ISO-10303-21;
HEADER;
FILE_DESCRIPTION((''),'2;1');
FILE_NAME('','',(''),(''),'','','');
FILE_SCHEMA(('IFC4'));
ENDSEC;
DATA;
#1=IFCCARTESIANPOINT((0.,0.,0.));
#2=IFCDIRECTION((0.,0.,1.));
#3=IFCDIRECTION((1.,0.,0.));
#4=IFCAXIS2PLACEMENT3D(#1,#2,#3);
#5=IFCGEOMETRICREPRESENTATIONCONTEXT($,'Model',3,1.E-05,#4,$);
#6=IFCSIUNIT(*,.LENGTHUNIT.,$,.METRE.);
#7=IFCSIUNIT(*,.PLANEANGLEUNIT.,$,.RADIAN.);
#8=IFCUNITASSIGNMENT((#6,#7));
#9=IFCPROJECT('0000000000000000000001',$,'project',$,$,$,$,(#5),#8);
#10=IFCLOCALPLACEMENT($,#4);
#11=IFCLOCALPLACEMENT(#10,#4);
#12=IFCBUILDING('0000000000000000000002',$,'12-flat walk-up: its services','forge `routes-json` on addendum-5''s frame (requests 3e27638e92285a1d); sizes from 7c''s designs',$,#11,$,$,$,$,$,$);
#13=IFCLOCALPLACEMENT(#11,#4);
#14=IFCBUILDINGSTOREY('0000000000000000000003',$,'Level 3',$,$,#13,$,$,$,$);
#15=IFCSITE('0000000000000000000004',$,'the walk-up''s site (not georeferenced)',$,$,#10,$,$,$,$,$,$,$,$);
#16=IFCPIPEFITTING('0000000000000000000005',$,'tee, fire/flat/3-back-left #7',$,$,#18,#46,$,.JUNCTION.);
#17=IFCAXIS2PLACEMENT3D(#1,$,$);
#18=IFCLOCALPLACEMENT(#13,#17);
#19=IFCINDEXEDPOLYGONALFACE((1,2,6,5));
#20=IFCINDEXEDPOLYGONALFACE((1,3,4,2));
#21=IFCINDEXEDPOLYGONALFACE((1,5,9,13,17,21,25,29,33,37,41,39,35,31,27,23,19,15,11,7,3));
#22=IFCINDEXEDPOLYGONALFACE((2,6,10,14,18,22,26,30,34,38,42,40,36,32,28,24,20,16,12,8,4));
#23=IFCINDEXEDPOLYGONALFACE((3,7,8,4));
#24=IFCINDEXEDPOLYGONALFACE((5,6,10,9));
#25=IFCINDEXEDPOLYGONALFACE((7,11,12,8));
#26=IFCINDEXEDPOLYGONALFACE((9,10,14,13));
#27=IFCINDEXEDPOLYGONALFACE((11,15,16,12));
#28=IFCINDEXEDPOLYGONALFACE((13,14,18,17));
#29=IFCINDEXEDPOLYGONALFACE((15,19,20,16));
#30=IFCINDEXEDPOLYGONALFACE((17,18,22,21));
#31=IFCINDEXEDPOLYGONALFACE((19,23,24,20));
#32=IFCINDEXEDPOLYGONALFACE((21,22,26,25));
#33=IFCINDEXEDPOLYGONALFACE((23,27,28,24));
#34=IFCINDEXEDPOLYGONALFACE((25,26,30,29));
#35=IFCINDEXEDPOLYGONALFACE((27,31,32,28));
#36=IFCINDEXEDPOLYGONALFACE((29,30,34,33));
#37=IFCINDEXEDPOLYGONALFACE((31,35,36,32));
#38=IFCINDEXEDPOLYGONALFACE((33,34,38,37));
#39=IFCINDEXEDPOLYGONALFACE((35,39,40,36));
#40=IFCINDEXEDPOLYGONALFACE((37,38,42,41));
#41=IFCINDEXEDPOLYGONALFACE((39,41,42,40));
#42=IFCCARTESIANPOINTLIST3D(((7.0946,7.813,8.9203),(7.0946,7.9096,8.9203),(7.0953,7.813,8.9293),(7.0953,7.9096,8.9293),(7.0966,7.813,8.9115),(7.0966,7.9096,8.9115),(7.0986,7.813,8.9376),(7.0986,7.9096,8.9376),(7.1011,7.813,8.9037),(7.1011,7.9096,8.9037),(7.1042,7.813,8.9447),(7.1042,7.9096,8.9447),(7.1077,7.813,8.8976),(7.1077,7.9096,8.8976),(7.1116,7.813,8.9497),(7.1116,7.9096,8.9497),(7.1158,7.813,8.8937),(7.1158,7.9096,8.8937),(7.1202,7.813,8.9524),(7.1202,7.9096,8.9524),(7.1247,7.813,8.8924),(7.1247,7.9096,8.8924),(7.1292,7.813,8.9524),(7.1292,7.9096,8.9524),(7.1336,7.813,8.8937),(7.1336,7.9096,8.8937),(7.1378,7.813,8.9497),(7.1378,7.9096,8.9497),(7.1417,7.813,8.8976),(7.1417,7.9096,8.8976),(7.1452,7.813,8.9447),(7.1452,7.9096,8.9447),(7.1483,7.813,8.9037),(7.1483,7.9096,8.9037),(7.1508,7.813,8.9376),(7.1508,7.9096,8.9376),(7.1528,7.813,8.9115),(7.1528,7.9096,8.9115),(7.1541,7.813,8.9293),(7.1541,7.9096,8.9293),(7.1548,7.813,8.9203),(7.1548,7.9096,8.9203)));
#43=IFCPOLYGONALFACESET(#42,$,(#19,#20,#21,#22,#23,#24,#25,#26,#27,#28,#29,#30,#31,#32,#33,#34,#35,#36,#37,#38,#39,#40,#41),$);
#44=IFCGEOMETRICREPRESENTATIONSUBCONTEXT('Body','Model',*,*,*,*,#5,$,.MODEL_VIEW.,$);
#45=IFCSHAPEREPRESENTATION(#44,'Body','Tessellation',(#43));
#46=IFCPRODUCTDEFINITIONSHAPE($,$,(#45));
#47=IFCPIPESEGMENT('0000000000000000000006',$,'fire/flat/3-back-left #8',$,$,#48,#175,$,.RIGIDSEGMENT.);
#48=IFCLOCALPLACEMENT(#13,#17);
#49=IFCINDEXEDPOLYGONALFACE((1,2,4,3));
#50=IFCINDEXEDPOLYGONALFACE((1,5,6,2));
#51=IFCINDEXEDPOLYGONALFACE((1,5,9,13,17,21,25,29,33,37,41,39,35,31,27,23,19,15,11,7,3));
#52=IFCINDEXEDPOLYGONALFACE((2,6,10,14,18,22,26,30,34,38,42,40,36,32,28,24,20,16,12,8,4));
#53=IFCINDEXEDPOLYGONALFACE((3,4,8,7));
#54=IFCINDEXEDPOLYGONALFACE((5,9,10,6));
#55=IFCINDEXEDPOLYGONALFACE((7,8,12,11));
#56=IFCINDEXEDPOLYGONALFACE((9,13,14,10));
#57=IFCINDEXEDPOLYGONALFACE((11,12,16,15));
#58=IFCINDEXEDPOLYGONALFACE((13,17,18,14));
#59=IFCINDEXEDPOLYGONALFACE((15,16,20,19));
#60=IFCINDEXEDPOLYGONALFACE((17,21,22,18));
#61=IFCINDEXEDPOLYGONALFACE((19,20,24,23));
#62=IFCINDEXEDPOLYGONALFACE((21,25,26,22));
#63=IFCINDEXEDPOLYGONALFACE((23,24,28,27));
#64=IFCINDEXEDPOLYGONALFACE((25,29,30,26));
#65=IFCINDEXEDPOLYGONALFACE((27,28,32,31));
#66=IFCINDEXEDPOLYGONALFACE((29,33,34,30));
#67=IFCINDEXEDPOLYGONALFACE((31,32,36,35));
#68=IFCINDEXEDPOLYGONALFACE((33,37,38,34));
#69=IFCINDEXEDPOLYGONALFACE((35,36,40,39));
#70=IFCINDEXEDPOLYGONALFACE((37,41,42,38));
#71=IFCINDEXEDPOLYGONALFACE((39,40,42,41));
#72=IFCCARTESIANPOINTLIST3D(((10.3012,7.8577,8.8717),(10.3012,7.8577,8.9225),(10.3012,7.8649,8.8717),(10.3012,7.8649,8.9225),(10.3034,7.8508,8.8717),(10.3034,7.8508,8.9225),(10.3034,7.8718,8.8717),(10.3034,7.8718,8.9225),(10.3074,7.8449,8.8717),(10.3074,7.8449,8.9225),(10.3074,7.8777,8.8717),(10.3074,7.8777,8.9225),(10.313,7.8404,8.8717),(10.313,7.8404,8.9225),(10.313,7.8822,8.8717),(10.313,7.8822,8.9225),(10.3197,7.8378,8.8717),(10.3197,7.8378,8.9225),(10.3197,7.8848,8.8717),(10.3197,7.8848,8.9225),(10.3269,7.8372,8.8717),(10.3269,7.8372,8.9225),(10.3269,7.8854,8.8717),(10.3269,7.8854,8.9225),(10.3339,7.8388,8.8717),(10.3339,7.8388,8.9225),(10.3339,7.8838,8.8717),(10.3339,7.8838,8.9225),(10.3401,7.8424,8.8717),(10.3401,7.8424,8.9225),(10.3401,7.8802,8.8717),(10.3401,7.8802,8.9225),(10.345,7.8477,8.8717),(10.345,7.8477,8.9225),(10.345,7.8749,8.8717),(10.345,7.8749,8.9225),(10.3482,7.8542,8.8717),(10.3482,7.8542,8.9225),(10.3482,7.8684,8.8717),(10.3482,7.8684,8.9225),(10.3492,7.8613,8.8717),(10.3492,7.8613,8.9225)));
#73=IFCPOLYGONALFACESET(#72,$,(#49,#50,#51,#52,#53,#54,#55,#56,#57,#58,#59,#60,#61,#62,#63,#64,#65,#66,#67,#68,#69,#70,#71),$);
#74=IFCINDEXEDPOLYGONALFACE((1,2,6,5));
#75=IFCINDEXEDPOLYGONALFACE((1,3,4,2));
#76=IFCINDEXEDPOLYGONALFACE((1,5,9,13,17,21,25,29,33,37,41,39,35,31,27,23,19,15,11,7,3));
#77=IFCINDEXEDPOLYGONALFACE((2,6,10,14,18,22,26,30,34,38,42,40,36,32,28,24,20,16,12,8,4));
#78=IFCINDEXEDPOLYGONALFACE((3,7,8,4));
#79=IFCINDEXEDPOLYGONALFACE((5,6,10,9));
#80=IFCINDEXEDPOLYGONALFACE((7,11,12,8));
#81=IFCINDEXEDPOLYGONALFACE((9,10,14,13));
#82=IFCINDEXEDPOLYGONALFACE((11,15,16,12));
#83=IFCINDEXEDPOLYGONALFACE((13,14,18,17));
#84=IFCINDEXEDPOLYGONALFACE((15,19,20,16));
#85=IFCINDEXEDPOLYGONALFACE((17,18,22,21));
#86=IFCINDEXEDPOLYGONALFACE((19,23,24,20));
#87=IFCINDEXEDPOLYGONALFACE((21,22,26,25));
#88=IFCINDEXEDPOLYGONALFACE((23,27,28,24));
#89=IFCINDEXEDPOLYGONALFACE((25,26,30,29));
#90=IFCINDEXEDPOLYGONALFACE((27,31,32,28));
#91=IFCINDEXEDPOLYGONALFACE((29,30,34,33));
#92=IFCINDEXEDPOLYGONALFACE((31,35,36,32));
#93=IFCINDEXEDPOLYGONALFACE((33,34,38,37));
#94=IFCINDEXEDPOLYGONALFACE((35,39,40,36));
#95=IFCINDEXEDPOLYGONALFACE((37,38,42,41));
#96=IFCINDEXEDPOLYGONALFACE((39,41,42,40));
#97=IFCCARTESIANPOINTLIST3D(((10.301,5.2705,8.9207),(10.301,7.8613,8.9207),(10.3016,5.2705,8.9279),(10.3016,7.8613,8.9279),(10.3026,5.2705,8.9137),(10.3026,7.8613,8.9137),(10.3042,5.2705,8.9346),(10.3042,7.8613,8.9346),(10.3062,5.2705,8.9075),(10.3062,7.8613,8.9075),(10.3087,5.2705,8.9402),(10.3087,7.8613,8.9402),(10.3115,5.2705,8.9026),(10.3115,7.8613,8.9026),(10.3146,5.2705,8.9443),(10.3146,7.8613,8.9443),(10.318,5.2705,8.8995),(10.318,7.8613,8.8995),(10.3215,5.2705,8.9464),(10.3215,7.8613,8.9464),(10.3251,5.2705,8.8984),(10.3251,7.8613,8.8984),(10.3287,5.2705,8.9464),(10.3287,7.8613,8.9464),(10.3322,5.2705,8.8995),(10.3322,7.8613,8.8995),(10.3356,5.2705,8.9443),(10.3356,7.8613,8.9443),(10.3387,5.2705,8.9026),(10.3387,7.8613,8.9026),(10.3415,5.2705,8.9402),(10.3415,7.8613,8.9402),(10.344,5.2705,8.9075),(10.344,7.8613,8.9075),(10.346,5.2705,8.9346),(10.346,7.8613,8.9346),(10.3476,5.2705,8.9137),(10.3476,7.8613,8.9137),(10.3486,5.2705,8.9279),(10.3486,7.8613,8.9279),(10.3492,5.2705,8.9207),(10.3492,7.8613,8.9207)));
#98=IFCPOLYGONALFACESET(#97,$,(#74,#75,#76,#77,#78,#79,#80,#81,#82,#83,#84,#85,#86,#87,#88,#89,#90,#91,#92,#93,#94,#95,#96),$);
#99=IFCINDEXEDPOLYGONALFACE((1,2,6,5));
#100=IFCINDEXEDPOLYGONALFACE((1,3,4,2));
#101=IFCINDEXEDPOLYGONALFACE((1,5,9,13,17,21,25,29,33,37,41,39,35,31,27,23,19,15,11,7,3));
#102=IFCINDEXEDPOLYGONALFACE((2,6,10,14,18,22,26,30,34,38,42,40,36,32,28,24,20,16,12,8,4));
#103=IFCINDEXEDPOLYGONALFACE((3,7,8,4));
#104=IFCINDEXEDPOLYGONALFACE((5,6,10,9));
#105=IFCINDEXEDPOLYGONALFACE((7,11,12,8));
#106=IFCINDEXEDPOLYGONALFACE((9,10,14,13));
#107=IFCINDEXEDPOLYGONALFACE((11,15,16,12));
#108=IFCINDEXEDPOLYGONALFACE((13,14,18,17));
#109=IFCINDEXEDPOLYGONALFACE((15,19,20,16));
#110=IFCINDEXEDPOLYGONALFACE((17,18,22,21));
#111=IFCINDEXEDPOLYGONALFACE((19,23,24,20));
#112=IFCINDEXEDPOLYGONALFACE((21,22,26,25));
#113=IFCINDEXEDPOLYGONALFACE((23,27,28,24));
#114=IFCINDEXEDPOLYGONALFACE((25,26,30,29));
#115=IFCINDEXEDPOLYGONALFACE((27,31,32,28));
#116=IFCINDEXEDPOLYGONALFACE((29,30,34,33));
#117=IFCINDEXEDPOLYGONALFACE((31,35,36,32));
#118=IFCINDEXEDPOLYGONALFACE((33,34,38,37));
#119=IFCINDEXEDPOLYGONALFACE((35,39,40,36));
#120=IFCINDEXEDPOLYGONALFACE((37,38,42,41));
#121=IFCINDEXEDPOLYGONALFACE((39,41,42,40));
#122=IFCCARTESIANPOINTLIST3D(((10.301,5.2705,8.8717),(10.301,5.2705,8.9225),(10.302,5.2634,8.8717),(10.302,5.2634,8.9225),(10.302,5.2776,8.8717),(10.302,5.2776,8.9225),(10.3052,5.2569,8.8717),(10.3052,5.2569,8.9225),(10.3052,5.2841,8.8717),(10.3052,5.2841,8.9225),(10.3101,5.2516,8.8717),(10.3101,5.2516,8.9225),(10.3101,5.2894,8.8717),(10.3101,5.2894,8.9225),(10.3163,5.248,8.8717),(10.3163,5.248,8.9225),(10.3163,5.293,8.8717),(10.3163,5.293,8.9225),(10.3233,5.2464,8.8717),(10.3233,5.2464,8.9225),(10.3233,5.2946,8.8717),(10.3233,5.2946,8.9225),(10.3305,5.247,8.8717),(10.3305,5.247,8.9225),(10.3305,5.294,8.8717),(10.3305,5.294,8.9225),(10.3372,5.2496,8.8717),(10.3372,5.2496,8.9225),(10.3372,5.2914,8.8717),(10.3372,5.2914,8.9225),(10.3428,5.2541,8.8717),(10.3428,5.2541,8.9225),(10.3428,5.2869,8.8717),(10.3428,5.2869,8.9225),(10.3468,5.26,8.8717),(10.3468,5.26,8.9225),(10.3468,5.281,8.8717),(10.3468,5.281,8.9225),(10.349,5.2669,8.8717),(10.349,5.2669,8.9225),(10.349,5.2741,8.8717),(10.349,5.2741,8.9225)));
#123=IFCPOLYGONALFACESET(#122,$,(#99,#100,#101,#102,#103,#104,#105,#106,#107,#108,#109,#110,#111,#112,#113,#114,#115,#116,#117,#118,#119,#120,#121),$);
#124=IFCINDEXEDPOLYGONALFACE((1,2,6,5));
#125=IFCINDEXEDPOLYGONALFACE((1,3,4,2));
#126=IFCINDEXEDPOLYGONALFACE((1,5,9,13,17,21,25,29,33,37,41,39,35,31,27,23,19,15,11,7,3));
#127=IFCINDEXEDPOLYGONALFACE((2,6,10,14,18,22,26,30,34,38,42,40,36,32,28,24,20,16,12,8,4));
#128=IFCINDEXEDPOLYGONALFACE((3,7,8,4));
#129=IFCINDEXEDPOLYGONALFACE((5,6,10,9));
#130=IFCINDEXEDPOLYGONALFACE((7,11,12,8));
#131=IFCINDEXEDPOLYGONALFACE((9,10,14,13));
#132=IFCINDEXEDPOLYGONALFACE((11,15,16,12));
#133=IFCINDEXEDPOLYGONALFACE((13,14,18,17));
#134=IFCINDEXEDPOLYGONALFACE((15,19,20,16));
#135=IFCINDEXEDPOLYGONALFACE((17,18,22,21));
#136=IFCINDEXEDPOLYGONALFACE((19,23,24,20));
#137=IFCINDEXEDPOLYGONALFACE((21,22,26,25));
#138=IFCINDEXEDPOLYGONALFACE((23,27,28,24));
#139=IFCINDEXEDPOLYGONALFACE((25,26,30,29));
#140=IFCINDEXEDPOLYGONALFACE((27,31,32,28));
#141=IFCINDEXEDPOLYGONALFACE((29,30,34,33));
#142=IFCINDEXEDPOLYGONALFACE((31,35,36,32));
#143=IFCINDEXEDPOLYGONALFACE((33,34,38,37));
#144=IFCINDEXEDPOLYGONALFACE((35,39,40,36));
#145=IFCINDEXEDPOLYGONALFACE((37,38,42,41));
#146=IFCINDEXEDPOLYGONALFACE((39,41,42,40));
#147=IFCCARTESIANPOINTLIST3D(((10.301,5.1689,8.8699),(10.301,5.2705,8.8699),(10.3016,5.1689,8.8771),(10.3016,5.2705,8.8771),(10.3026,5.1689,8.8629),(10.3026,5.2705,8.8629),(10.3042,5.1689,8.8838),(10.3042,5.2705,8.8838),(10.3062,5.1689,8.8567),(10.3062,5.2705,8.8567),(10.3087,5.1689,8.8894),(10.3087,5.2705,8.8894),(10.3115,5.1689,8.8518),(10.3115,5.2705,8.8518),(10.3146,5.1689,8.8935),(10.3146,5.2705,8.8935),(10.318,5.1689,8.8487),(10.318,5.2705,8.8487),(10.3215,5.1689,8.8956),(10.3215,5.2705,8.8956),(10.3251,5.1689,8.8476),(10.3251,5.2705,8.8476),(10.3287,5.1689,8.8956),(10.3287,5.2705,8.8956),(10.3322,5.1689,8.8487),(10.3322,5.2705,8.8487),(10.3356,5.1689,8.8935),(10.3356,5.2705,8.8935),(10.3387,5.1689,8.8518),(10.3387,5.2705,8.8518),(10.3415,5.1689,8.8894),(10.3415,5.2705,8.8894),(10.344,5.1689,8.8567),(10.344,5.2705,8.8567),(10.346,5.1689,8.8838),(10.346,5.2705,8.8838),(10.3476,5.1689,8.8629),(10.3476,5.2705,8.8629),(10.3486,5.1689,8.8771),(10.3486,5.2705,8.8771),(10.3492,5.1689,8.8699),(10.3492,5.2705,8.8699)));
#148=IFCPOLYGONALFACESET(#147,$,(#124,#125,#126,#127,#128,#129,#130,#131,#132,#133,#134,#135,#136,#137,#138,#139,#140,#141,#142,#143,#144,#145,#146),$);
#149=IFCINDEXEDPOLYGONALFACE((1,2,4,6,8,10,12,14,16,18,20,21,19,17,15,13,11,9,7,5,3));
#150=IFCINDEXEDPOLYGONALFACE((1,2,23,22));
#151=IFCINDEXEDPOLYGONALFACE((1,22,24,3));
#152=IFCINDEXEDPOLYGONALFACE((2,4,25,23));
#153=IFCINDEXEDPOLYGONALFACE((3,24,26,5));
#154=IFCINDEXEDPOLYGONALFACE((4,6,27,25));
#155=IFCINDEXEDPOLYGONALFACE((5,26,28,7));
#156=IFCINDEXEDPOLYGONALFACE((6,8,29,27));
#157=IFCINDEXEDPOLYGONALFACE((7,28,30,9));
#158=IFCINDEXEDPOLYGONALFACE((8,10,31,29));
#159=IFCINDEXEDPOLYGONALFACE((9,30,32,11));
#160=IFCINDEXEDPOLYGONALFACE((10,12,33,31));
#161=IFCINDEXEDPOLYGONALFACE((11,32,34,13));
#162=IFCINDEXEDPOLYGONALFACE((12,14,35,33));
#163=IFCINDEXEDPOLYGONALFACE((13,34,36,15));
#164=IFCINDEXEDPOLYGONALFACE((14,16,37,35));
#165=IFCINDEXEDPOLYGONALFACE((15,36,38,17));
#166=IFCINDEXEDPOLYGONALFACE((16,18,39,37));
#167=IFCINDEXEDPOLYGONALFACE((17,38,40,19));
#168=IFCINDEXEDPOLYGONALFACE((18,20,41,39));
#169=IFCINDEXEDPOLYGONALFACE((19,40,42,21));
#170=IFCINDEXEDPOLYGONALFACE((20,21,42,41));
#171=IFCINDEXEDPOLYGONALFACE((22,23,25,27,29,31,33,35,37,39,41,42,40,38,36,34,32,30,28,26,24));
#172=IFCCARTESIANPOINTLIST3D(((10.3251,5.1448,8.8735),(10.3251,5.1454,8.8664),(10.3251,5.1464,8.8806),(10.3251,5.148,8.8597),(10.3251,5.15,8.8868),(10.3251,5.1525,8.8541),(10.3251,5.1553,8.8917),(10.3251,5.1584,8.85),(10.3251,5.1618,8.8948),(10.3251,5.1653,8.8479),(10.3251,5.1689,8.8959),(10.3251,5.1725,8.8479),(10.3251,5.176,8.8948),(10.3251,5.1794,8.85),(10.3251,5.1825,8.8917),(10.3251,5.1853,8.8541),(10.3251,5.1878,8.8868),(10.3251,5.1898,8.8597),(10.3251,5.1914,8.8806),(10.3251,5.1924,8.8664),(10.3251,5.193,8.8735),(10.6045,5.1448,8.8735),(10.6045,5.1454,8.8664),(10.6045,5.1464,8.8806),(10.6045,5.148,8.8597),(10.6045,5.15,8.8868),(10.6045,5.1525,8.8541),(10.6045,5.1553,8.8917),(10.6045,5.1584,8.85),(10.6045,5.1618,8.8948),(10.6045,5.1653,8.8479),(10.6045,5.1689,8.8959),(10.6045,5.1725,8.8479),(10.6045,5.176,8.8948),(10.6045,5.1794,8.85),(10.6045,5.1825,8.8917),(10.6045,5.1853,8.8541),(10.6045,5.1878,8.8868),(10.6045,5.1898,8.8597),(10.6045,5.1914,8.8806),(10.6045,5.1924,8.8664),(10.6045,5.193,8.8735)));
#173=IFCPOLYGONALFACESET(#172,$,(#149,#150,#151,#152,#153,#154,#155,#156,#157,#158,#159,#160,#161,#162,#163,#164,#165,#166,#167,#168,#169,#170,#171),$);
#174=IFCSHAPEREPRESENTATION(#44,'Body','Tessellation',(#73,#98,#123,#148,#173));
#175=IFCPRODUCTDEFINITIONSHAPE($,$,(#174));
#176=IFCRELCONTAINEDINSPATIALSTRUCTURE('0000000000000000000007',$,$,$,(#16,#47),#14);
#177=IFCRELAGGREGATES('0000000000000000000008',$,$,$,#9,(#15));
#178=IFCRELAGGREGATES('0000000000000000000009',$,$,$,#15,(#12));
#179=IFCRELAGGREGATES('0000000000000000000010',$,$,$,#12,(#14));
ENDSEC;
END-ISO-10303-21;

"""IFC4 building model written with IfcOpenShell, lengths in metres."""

from ifc_helpers import new_model, entity, si_unit, frame, origin_with_axes, place, context, subcontext, project, spatial, element, save


model = new_model("IFC4")

# Units and contexts
model_context = context("Model", 3, precision=1e-05, world=origin_with_axes())
body_context = subcontext(model_context, "Body", "Model", "MODEL_VIEW")
ifc_project = project(units=[si_unit("LENGTHUNIT", "METRE"), si_unit("PLANEANGLEUNIT", "RADIAN")], contexts=[model_context])

# Site, building, storey
site_placement = place(None, origin_with_axes())
site = spatial("IfcSite", under=ifc_project, at=site_placement, Name="the walk-up's site (not georeferenced)")
building_placement = place(site_placement, origin_with_axes())
building = spatial("IfcBuilding", under=site, at=building_placement, Name="12-flat walk-up: its services", Description="forge `routes-json` on addendum-5's frame (requests 3e27638e92285a1d); sizes from 7c's designs")
storey_placement = place(building_placement, origin_with_axes())
storey = spatial("IfcBuildingStorey", under=building, at=storey_placement, Name="Level 3")

# Pipe fitting
pipe_fitting_1_placement = place(storey_placement, frame((7.1247, 7.9096, 8.9225), z_axis=(0.0, 0.0, 1.0), x_axis=(1.0, 0.0, 0.0)))
element("IfcPipeFitting", 1, at=pipe_fitting_1_placement, inside=storey, Name="tee, fire/flat/3-back-left #7", PredefinedType="JUNCTION", context=body_context, shape_type="AdvancedSweptSolid", body=[
    entity("IfcSweptDiskSolid", entity("IfcPolyline", [entity("IfcCartesianPoint", [0.0, 0.0, 0.0]), entity("IfcCartesianPoint", [0.0, -0.0965, 0.0])]), 0.0302),
])

# Pipe segment
pipe_segment_1_placement = place(storey_placement, frame((10.3251, 7.8613, 8.8717), z_axis=(0.0, 0.0, 1.0), x_axis=(1.0, 0.0, 0.0)))
element("IfcPipeSegment", 2, at=pipe_segment_1_placement, inside=storey, Name="fire/flat/3-back-left #8", PredefinedType="RIGIDSEGMENT", context=body_context, shape_type="AdvancedSweptSolid", body=[
    entity("IfcSweptDiskSolid", entity("IfcPolyline", [entity("IfcCartesianPoint", [0.0, 0.0, 0.0]), entity("IfcCartesianPoint", [0.0, 0.0, 0.0508])]), 0.0241),
    entity("IfcSweptDiskSolid", entity("IfcPolyline", [entity("IfcCartesianPoint", [0.0, 0.0, 0.0508]), entity("IfcCartesianPoint", [0.0, -2.5908, 0.0508])]), 0.0241),
    entity("IfcSweptDiskSolid", entity("IfcPolyline", [entity("IfcCartesianPoint", [0.0, -2.5908, 0.0508]), entity("IfcCartesianPoint", [0.0, -2.5908, 0.0])]), 0.0241),
    entity("IfcSweptDiskSolid", entity("IfcPolyline", [entity("IfcCartesianPoint", [0.0, -2.5908, 0.0]), entity("IfcCartesianPoint", [0.0, -2.6924, 0.0])]), 0.0241),
    entity("IfcSweptDiskSolid", entity("IfcPolyline", [entity("IfcCartesianPoint", [0.0, -2.6924, 0.0]), entity("IfcCartesianPoint", [0.2794, -2.6924, 0.0])]), 0.0241),
])

save(model, "model.ifc")
